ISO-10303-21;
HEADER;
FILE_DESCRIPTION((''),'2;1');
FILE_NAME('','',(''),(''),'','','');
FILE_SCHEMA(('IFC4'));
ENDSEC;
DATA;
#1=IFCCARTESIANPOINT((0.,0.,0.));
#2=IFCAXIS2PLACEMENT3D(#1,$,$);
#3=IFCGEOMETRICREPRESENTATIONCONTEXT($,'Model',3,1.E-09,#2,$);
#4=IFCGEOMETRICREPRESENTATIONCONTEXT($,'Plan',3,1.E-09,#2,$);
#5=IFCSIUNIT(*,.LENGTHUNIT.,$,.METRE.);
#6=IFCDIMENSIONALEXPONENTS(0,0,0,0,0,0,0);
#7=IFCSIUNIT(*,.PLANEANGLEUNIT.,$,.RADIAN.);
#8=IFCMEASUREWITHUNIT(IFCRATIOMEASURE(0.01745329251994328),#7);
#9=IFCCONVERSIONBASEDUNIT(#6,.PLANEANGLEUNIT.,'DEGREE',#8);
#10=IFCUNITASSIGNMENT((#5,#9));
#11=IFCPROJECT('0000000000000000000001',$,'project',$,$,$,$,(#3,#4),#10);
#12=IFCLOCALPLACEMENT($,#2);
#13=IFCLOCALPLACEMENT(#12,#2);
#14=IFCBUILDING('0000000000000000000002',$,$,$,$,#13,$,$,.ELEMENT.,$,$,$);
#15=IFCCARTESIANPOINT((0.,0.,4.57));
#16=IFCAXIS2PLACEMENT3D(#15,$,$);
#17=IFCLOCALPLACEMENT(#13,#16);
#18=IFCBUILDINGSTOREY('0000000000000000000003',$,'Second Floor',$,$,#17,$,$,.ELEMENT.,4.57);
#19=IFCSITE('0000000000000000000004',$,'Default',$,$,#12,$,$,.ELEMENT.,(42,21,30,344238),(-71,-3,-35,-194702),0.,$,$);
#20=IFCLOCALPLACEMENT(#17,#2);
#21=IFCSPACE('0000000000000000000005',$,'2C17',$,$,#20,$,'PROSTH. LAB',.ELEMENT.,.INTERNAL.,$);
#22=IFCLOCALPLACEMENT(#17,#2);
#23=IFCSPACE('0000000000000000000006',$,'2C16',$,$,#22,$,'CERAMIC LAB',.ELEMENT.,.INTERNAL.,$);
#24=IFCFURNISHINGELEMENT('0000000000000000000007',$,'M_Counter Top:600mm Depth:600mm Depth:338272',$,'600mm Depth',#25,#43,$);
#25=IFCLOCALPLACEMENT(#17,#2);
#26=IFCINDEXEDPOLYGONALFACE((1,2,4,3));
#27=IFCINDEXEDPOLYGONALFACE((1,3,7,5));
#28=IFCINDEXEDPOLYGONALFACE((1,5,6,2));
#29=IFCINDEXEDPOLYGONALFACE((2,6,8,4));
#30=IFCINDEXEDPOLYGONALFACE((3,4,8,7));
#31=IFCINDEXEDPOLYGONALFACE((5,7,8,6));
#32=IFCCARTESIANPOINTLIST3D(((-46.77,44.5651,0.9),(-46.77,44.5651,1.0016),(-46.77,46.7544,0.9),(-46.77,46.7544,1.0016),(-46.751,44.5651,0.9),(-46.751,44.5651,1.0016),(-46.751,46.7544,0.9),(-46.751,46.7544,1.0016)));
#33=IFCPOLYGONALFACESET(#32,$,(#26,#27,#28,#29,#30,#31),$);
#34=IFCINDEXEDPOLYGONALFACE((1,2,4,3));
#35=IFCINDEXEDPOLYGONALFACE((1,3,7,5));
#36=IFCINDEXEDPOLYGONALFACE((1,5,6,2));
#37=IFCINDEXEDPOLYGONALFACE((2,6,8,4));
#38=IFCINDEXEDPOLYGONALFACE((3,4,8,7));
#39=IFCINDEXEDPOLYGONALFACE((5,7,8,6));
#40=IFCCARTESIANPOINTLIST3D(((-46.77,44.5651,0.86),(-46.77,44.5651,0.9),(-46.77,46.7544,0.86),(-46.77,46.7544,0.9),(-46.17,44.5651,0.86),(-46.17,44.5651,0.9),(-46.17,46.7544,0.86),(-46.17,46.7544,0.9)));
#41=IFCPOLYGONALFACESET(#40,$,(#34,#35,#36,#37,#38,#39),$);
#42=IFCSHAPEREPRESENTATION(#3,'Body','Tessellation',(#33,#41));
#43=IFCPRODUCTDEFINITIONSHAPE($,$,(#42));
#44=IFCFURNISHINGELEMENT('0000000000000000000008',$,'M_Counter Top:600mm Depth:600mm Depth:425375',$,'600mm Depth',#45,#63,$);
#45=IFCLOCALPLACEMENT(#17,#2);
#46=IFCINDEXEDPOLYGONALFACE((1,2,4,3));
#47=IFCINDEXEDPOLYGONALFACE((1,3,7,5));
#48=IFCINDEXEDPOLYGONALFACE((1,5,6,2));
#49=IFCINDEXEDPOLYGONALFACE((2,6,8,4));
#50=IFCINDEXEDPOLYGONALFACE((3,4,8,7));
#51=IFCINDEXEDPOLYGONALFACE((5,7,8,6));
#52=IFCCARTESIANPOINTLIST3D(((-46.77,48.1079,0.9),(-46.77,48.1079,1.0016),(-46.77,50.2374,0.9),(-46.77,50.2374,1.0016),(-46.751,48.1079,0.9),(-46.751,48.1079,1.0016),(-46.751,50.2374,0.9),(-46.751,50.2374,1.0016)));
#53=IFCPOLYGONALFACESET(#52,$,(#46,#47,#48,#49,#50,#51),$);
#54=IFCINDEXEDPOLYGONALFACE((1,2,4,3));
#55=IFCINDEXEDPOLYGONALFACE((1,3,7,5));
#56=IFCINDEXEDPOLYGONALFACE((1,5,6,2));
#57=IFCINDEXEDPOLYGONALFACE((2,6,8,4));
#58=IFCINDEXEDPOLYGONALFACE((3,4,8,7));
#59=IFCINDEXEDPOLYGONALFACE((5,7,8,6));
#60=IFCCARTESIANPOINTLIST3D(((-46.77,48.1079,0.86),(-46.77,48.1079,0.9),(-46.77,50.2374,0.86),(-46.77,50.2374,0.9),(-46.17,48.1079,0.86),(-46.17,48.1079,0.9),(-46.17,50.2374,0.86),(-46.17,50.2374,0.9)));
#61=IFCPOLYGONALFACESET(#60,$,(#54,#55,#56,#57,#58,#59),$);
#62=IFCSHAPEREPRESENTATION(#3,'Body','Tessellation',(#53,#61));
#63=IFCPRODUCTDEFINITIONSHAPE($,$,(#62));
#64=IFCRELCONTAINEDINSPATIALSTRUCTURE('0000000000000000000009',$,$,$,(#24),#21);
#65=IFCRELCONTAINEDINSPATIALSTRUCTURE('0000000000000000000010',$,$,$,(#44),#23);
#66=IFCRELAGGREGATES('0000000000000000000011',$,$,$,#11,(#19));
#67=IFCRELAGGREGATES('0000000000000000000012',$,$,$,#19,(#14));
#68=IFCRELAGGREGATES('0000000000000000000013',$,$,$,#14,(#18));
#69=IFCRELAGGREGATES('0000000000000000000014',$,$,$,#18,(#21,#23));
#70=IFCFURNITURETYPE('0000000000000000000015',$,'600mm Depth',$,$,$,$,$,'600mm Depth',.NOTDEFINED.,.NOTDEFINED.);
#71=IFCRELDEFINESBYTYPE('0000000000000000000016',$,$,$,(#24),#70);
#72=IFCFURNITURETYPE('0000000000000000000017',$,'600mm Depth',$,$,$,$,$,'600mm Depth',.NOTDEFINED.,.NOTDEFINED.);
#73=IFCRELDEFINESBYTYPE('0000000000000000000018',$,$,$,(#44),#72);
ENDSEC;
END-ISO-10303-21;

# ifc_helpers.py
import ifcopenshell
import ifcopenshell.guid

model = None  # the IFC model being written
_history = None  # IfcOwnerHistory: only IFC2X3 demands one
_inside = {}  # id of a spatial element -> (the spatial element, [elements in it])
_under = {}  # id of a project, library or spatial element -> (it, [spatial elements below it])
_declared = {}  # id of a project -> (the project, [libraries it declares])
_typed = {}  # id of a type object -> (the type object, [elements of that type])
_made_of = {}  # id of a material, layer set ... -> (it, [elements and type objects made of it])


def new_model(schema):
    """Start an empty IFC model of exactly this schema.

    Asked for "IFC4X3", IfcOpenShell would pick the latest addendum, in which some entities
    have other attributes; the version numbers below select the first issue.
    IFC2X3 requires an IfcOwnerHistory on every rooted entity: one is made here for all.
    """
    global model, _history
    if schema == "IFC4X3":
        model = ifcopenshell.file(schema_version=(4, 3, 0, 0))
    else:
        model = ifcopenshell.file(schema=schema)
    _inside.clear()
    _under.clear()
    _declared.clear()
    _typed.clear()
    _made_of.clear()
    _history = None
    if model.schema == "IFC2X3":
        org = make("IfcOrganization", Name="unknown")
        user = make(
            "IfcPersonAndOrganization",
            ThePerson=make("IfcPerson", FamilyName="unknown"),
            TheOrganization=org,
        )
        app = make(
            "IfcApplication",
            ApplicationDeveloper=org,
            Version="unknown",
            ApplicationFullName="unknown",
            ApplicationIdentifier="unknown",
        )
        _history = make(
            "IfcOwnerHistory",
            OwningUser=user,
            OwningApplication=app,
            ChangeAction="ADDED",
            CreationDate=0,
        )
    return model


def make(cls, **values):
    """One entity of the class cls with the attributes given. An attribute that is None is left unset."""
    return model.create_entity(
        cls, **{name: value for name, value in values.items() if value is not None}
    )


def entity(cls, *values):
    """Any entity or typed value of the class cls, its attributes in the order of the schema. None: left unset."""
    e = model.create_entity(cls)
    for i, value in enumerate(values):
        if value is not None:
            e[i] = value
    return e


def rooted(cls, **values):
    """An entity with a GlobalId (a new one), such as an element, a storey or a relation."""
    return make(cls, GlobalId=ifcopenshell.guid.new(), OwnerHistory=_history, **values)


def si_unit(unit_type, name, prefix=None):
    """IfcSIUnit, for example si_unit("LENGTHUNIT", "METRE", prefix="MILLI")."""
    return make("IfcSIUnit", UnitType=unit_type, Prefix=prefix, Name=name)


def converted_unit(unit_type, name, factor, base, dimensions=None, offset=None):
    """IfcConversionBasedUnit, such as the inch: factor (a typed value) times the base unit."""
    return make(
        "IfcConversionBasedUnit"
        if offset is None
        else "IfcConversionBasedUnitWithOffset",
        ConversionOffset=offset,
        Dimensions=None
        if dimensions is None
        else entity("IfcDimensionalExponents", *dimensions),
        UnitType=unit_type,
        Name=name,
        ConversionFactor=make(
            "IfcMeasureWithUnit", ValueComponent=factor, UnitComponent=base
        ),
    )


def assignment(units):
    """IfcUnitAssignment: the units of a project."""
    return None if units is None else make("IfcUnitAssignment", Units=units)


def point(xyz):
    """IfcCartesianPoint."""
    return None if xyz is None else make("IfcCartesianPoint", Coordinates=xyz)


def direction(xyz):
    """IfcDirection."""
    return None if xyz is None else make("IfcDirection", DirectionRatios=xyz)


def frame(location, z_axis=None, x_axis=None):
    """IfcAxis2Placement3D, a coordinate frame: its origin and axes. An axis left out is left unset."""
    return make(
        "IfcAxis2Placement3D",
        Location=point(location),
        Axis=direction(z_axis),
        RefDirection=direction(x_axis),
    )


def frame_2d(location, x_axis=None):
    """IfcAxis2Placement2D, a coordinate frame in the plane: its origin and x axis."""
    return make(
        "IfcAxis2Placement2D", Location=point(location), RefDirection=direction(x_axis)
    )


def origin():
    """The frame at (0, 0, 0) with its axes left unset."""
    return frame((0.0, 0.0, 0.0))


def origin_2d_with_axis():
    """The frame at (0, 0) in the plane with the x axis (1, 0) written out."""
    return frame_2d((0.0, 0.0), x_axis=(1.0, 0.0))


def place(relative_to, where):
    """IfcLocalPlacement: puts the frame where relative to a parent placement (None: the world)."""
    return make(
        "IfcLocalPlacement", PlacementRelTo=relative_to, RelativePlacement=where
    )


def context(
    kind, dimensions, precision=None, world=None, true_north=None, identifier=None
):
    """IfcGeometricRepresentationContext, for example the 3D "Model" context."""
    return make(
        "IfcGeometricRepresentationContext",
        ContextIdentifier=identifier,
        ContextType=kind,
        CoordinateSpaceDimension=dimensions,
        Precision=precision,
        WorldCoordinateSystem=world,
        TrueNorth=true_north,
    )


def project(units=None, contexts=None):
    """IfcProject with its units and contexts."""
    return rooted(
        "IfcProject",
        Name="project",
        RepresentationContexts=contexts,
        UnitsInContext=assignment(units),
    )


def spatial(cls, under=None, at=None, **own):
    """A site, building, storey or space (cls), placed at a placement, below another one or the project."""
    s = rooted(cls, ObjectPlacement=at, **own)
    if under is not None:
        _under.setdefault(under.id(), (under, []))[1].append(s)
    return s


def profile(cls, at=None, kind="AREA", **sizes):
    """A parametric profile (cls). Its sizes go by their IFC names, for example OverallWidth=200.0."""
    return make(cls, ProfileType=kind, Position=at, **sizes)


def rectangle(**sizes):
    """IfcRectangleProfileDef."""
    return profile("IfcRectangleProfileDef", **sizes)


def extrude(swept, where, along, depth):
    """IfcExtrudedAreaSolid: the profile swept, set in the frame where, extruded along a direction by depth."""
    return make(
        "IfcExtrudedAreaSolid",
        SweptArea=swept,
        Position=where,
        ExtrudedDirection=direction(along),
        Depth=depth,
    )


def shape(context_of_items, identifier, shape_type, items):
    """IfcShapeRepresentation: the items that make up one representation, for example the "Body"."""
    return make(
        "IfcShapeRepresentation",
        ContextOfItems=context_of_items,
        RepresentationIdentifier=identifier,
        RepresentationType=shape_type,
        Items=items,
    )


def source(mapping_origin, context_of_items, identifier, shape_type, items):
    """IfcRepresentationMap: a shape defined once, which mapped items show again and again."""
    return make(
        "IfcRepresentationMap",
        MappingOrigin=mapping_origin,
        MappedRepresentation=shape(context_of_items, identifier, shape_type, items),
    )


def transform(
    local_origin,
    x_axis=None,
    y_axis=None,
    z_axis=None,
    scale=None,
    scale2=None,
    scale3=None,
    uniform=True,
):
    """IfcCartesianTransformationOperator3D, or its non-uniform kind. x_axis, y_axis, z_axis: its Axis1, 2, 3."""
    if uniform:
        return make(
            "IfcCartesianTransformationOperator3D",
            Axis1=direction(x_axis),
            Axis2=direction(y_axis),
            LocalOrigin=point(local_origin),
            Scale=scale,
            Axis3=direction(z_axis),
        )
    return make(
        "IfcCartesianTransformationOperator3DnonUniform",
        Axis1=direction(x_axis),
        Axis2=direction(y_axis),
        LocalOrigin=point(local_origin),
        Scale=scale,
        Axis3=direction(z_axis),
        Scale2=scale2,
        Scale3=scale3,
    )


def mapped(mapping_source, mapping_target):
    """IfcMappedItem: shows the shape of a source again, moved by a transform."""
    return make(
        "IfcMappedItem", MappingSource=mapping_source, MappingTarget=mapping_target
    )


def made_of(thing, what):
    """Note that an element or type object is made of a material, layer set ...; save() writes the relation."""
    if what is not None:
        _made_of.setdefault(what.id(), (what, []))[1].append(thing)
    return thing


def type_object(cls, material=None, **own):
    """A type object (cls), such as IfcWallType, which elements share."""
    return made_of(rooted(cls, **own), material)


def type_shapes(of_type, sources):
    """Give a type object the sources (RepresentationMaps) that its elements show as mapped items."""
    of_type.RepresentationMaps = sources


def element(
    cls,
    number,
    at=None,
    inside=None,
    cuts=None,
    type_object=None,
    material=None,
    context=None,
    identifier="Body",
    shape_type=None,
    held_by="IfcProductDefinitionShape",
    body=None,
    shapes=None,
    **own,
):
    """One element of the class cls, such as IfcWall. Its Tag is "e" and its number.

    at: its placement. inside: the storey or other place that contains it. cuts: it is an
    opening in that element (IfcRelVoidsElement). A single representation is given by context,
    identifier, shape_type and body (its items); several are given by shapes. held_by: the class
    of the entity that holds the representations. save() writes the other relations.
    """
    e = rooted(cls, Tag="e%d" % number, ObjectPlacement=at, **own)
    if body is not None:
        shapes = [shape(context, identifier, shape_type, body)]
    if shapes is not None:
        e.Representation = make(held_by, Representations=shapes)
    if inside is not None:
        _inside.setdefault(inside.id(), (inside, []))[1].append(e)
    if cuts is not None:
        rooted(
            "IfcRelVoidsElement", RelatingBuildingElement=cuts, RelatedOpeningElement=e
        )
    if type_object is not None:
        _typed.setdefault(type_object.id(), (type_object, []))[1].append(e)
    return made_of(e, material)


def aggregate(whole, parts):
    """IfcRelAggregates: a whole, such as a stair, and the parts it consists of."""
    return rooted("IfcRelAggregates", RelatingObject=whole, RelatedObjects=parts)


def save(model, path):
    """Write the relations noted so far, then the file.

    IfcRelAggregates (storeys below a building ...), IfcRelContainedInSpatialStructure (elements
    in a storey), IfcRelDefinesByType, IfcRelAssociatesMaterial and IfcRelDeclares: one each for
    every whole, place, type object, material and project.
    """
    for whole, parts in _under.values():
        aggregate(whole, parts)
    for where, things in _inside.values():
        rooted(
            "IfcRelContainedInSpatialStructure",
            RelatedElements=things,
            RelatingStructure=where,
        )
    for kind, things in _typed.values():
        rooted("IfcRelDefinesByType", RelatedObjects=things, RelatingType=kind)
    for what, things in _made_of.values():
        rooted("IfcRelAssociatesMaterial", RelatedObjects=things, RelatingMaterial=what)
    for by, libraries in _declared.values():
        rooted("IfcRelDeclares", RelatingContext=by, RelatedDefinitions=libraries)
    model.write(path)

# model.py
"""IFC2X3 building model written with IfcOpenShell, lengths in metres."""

from ifc_helpers import new_model, entity, si_unit, converted_unit, frame, origin, origin_2d_with_axis, place, context, project, spatial, rectangle, extrude, source, transform, mapped, type_object, type_shapes, element, save


model = new_model("IFC2X3")

# Units and contexts
model_context = context("Model", 3, precision=1e-09, world=origin())
plan_context = context("Plan", 3, precision=1e-09, world=origin())
ifc_project = project(units=[si_unit("LENGTHUNIT", "METRE"), converted_unit("PLANEANGLEUNIT", "DEGREE", entity("IfcRatioMeasure", 0.01745329251994328), si_unit("PLANEANGLEUNIT", "RADIAN"), dimensions=[0, 0, 0, 0, 0, 0, 0])], contexts=[model_context, plan_context])

# Site, building, storey
site_placement = place(None, origin())
site = spatial("IfcSite", under=ifc_project, at=site_placement, Name="Default", CompositionType="ELEMENT", RefLatitude=(42, 21, 30, 344238), RefLongitude=(-71, -3, -35, -194702), RefElevation=0.0)
building_placement = place(site_placement, origin())
building = spatial("IfcBuilding", under=site, at=building_placement, CompositionType="ELEMENT")
storey_placement = place(building_placement, frame((0.0, 0.0, 4.57)))
storey = spatial("IfcBuildingStorey", under=building, at=storey_placement, Name="Second Floor", CompositionType="ELEMENT", Elevation=4.57)

# Shared definitions
space_1_placement = place(storey_placement, origin())
space_1 = spatial("IfcSpace", under=storey, at=space_1_placement, Name="2C17", LongName="PROSTH. LAB", CompositionType="ELEMENT", InteriorOrExteriorSpace="INTERNAL")

# Furnishing element
furniture_type_1 = type_object("IfcFurnitureType", Name="600mm Depth", ElementType="600mm Depth", AssemblyPlace="NOTDEFINED")
shared_shape_1 = source(origin(), model_context, "Body", "SweptSolid", [
    extrude(rectangle(XDim=0.0191, YDim=2.1893, at=origin_2d_with_axis()), frame((-0.1058, -0.0095, 0.9), z_axis=(0.0, 0.0, 1.0), x_axis=(0.0, -1.0, 0.0)), (0.0, 0.0, 1.0), 0.1016),
    extrude(rectangle(XDim=2.1893, YDim=0.6, at=origin_2d_with_axis()), frame((-0.1058, -0.3, 0.86), z_axis=(0.0, 0.0, 1.0), x_axis=(-1.0, 0.0, 0.0)), (0.0, 0.0, 1.0), 0.04),
])
type_shapes(furniture_type_1, [shared_shape_1])
furnishing_1_placement = place(space_1_placement, frame((-46.77, 45.7656, 0.0), z_axis=(0.0, 0.0, 1.0), x_axis=(0.0, 1.0, 0.0)))
element("IfcFurnishingElement", 1, at=furnishing_1_placement, inside=space_1, type_object=furniture_type_1, Name="M_Counter Top:600mm Depth:600mm Depth:338272", ObjectType="600mm Depth", context=model_context, shape_type="MappedRepresentation", body=[
    mapped(shared_shape_1, transform((0.0, 0.0, 0.0), scale=1.0)),
])

# Shared definitions
space_2_placement = place(storey_placement, origin())
space_2 = spatial("IfcSpace", under=storey, at=space_2_placement, Name="2C16", LongName="CERAMIC LAB", CompositionType="ELEMENT", InteriorOrExteriorSpace="INTERNAL")

# Furnishing element
furniture_type_2 = type_object("IfcFurnitureType", Name="600mm Depth", ElementType="600mm Depth", AssemblyPlace="NOTDEFINED")
shared_shape_2 = source(origin(), model_context, "Body", "SweptSolid", [
    extrude(rectangle(XDim=0.0191, YDim=2.1295, at=origin_2d_with_axis()), frame((-0.1357, -0.0095, 0.9), z_axis=(0.0, 0.0, 1.0), x_axis=(0.0, -1.0, 0.0)), (0.0, 0.0, 1.0), 0.1016),
    extrude(rectangle(XDim=2.1295, YDim=0.6, at=origin_2d_with_axis()), frame((-0.1357, -0.3, 0.86), z_axis=(0.0, 0.0, 1.0), x_axis=(-1.0, 0.0, 0.0)), (0.0, 0.0, 1.0), 0.04),
])
type_shapes(furniture_type_2, [shared_shape_2])
furnishing_2_placement = place(space_2_placement, frame((-46.77, 49.3084, 0.0), z_axis=(0.0, 0.0, 1.0), x_axis=(0.0, 1.0, 0.0)))
element("IfcFurnishingElement", 2, at=furnishing_2_placement, inside=space_2, type_object=furniture_type_2, Name="M_Counter Top:600mm Depth:600mm Depth:425375", ObjectType="600mm Depth", context=model_context, shape_type="MappedRepresentation", body=[
    mapped(shared_shape_2, transform((0.0, 0.0, 0.0), scale=1.0)),
])

save(model, "model.ifc")
